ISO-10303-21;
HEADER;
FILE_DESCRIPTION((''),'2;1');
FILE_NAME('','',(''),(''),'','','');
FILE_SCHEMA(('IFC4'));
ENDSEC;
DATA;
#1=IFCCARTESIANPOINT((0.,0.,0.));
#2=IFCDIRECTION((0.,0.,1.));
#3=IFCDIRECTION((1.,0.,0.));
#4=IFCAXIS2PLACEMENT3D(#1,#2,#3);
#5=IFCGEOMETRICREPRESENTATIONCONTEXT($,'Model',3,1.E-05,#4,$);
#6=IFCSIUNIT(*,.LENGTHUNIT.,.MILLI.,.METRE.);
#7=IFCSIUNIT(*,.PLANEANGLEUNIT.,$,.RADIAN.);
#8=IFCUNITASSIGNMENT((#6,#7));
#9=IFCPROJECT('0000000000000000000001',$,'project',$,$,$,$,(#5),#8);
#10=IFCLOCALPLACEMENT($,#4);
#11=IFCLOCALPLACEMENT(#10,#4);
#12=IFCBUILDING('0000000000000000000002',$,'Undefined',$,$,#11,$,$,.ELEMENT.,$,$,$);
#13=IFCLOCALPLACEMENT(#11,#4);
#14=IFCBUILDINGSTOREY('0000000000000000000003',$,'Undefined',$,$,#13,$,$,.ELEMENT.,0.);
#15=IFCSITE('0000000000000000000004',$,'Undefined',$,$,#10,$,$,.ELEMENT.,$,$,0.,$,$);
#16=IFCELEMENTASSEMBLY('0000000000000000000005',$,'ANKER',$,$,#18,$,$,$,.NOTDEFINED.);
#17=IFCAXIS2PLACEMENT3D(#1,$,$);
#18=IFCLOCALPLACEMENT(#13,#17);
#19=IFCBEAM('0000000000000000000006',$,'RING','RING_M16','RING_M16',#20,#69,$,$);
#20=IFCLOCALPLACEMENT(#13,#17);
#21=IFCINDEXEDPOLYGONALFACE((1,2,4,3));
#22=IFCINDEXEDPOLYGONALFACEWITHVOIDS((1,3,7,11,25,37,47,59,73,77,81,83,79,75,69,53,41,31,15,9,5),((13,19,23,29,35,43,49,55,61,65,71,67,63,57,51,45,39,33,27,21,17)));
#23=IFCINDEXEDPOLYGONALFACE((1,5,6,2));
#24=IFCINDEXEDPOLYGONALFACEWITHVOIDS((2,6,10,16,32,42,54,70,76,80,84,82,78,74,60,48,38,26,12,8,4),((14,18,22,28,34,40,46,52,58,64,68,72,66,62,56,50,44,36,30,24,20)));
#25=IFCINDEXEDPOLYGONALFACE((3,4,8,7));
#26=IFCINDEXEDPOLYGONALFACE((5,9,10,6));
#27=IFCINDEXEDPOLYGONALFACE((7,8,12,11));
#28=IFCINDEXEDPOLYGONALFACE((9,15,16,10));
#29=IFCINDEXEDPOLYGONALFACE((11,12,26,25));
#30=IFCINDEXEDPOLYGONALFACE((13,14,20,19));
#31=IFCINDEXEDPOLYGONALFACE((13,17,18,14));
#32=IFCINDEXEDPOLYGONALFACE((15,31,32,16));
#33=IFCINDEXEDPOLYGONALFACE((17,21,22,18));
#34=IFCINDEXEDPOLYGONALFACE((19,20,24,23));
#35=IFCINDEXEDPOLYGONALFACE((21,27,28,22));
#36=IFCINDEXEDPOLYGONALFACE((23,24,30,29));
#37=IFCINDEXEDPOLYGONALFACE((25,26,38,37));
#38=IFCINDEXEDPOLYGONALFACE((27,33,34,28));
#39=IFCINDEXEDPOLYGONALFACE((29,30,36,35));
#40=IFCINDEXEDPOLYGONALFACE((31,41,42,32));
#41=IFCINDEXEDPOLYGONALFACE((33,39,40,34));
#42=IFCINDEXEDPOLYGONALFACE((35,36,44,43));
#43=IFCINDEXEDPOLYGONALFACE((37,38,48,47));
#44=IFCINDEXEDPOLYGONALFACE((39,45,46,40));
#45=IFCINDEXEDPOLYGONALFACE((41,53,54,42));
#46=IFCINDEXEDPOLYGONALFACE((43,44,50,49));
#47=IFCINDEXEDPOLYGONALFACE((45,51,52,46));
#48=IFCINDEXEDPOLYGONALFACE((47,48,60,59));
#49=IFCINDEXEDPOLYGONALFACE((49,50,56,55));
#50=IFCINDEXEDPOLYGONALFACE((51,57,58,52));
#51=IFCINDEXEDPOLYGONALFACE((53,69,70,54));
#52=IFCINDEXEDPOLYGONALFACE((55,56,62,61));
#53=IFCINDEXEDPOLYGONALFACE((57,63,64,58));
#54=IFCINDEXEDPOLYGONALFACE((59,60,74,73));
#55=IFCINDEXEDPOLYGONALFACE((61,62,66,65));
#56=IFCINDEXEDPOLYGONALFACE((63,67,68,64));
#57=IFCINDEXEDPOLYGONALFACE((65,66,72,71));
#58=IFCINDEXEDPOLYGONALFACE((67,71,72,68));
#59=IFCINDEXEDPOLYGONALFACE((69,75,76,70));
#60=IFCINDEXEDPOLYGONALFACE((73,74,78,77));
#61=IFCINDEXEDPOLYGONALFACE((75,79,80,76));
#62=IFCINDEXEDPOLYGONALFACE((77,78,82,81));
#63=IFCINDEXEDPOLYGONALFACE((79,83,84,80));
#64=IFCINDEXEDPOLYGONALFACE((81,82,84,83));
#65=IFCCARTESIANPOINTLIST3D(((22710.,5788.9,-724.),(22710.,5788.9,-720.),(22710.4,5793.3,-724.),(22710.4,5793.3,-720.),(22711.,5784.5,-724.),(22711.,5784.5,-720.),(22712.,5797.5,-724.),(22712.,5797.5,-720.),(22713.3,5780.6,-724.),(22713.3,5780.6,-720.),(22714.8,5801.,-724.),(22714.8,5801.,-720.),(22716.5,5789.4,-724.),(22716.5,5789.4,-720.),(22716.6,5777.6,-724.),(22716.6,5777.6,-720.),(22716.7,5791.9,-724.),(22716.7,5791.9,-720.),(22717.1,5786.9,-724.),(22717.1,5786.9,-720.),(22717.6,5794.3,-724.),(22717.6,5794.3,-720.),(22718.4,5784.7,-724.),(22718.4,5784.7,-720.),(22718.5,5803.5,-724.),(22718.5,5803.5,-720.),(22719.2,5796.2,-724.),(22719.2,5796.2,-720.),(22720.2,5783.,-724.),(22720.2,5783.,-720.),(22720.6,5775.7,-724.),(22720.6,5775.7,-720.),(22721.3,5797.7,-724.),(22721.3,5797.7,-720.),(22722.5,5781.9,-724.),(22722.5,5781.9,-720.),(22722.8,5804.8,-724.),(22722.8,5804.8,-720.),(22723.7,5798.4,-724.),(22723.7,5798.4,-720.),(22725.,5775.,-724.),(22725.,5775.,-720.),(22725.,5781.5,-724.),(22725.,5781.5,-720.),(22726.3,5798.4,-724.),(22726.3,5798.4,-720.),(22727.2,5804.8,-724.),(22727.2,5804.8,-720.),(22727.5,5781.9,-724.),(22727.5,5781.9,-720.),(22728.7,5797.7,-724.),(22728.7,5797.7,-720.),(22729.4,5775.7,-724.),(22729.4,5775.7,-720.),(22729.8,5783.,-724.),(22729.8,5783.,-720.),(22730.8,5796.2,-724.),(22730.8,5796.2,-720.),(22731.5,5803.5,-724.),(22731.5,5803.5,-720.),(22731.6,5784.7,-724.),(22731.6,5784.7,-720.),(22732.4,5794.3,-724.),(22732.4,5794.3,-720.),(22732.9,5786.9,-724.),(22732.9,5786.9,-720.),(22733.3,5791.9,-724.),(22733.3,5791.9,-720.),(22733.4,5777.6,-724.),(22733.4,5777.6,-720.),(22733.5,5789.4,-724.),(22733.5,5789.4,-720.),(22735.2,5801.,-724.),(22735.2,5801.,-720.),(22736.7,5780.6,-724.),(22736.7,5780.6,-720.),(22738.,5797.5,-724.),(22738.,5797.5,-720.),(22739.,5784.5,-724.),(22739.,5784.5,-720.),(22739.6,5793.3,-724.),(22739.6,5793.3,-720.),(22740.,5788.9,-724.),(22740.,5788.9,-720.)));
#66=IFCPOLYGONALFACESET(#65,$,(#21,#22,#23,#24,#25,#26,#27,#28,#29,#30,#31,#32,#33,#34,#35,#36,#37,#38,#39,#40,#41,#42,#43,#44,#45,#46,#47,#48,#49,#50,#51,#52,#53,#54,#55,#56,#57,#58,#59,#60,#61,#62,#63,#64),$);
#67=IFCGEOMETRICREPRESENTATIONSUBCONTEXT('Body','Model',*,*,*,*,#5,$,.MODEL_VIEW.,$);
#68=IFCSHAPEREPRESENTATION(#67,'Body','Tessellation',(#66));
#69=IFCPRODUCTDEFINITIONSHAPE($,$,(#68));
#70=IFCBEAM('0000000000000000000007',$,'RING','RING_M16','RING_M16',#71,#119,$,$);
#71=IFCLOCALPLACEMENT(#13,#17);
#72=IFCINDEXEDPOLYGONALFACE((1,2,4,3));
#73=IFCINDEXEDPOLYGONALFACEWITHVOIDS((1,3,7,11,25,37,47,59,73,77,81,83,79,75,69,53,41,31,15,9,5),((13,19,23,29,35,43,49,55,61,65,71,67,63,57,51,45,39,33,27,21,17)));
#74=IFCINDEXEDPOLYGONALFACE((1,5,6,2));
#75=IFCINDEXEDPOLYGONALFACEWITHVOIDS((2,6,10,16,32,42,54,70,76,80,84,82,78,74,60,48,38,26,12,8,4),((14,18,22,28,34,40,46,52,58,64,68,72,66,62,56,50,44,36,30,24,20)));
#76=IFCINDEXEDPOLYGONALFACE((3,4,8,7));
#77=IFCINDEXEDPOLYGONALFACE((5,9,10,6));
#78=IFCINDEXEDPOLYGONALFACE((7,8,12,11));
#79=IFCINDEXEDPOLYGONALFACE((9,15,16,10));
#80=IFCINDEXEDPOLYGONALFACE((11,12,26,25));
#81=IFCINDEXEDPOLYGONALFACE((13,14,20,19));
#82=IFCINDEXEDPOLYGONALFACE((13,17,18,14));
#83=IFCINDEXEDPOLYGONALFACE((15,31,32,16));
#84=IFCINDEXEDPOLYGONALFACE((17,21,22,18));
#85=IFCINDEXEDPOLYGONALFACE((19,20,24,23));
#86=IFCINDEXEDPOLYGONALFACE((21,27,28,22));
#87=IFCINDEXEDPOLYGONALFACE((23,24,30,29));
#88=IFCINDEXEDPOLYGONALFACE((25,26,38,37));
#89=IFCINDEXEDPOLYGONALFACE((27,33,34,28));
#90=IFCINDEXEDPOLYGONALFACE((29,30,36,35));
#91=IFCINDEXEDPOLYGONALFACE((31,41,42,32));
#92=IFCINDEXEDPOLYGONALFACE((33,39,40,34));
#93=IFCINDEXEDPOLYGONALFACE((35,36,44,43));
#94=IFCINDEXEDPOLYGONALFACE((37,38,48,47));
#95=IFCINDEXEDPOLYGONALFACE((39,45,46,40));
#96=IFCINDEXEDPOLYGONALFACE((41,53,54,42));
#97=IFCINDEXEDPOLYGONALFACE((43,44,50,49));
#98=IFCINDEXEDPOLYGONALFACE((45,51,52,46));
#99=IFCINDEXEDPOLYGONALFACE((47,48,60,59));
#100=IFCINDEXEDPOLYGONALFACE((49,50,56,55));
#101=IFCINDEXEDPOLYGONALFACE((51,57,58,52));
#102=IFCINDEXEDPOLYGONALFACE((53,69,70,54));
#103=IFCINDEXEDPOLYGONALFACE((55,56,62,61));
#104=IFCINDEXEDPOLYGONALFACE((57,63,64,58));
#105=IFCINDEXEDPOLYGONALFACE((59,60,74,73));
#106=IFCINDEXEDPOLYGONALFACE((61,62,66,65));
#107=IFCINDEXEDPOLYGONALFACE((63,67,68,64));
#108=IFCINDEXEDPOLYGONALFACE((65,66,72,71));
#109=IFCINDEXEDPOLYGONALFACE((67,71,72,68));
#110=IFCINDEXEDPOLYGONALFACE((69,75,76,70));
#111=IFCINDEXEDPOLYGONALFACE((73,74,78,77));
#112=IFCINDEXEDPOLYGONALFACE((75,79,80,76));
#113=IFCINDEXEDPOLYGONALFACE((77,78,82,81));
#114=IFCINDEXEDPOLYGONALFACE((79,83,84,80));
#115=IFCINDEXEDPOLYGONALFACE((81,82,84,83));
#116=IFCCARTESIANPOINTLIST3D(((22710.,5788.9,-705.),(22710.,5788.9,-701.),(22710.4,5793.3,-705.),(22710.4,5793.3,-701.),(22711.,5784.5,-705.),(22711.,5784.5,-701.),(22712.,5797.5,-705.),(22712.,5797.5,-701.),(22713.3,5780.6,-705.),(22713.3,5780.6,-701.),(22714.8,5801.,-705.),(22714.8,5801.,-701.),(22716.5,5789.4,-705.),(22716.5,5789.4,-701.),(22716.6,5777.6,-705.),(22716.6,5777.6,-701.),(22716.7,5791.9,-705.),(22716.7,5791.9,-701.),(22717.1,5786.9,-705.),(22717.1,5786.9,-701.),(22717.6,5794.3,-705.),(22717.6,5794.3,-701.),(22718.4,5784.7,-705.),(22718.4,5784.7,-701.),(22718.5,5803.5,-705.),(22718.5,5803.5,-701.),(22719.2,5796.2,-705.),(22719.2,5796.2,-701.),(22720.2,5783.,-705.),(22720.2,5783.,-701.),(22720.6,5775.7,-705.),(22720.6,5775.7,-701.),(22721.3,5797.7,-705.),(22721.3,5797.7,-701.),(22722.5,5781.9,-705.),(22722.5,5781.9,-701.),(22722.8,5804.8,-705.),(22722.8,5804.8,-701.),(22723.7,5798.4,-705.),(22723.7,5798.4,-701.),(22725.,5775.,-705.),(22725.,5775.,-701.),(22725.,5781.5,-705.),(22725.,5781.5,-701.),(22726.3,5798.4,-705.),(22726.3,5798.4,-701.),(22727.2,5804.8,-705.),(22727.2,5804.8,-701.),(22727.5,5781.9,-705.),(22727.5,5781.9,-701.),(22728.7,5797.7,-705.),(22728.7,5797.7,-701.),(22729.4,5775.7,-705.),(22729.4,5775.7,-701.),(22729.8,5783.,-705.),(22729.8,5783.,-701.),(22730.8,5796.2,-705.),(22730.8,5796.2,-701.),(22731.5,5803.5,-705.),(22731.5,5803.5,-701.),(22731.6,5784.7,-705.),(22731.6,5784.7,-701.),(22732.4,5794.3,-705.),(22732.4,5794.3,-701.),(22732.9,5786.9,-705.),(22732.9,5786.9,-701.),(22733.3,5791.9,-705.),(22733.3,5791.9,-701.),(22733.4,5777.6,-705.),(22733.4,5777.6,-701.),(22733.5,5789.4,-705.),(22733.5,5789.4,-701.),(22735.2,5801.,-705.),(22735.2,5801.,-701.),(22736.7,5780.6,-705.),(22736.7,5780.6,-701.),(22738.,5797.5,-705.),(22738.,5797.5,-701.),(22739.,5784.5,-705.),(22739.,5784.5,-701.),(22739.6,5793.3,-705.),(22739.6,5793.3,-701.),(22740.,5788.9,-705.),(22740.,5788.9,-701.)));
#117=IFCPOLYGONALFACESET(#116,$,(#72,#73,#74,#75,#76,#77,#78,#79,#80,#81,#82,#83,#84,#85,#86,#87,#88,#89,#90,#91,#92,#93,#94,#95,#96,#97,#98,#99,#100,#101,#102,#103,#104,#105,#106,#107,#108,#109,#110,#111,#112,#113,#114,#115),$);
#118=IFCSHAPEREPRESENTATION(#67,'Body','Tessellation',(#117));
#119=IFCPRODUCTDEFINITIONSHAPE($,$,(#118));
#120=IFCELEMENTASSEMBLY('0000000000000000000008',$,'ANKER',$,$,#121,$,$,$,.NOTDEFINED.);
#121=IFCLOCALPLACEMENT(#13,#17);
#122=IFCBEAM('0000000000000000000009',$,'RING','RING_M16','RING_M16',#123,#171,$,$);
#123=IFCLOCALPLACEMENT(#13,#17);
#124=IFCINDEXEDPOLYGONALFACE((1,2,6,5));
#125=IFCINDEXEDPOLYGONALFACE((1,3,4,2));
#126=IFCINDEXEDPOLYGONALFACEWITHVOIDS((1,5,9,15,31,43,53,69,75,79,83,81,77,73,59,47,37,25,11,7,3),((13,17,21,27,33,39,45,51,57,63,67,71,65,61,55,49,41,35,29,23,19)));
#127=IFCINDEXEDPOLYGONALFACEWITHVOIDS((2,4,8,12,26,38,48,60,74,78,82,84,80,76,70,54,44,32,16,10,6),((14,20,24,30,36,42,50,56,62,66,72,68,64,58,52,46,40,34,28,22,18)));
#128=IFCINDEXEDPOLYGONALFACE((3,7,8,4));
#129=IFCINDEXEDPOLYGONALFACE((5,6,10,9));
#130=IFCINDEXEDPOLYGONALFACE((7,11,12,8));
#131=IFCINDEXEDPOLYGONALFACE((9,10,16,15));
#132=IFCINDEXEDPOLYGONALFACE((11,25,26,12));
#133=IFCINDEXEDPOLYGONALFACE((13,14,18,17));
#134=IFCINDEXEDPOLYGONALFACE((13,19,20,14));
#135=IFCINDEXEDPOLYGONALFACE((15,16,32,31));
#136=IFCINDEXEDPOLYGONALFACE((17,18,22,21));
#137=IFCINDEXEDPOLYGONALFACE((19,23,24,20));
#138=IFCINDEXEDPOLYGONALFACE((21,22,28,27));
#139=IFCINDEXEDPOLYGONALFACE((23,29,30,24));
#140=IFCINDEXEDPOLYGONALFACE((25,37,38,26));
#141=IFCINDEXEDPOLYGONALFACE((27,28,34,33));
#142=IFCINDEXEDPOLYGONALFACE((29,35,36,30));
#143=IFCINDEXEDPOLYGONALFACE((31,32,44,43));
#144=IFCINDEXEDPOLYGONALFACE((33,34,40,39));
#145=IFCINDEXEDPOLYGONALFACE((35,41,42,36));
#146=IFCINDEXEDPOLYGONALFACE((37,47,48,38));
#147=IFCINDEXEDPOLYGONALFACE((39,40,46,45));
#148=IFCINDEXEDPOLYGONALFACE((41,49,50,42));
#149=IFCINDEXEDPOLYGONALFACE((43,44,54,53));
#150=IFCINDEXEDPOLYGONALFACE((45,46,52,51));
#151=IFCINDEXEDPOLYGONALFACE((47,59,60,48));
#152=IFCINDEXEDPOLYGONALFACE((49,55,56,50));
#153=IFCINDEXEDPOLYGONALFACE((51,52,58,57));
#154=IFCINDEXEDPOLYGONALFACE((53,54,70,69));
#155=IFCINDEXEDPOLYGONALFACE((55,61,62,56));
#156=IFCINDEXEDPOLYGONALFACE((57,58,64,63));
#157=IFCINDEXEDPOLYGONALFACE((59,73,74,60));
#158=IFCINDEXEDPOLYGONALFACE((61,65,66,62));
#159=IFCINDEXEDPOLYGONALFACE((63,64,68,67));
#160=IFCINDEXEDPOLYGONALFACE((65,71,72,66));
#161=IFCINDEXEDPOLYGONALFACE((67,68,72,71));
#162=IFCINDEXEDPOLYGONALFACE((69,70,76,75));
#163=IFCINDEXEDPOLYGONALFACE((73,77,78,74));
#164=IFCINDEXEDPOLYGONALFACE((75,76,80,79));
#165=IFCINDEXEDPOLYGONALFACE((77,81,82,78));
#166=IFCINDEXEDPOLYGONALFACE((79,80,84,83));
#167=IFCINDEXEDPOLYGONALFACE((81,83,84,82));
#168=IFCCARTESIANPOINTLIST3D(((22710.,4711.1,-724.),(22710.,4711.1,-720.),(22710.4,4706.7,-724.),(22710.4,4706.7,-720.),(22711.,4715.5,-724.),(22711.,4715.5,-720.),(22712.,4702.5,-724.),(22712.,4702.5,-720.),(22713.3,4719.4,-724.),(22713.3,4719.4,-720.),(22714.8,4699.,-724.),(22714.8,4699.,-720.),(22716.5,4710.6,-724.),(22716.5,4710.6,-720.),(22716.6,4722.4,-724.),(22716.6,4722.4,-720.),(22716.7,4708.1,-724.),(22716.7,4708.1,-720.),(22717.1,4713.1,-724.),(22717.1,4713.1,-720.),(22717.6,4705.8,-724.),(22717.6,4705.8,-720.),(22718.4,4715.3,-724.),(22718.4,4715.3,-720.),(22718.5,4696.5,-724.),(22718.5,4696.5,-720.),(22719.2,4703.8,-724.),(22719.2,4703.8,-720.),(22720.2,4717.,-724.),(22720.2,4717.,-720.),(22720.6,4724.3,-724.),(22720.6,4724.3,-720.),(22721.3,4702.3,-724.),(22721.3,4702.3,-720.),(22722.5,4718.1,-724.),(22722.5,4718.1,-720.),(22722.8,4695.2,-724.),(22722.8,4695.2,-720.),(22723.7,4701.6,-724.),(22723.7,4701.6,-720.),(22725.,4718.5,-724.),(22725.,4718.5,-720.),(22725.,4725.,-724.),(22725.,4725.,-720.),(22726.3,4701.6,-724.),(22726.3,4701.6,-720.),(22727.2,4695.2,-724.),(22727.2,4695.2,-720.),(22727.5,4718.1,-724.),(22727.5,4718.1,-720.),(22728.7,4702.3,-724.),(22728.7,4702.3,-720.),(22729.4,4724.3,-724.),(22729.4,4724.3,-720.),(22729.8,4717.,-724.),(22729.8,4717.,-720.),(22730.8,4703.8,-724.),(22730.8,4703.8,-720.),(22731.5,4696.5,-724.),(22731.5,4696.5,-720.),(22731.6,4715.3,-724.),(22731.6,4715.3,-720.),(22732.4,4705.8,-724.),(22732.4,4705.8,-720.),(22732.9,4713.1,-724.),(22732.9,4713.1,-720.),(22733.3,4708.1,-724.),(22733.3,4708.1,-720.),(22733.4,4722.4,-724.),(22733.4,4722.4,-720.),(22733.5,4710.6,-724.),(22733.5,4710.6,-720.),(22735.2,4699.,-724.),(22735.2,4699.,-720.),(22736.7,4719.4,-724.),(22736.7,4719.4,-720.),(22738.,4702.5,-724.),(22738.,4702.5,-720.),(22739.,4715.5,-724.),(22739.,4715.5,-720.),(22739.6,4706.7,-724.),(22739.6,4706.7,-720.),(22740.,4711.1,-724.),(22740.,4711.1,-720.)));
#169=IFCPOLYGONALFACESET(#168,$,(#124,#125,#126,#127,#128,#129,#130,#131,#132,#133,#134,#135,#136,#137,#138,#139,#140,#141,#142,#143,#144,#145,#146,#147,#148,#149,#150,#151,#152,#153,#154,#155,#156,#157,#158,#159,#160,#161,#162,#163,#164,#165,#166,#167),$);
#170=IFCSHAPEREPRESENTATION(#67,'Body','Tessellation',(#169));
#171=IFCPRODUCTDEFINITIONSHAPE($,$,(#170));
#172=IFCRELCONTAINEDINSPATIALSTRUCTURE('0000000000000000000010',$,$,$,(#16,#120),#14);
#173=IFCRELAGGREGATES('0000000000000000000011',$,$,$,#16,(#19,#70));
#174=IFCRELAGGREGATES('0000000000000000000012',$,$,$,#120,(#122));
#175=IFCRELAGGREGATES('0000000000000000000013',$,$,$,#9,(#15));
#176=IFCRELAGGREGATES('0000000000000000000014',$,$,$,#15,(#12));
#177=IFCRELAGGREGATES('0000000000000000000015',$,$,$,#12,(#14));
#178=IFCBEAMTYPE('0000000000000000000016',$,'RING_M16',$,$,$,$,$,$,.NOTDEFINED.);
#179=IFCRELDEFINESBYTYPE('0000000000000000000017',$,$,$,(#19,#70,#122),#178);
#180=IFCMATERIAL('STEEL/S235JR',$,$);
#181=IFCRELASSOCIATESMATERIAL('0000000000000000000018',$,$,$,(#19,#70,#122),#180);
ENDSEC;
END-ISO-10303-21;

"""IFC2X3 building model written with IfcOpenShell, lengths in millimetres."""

from ifc_helpers import new_model, si_unit, frame, origin_with_axes, origin_2d_with_axis, place, context, subcontext, project, spatial, hollow_circle, extrude, material, type_object, element, aggregate, save


model = new_model("IFC2X3")

# Units and contexts
model_context = context("Model", 3, precision=1e-05, world=origin_with_axes())
body_context = subcontext(model_context, "Body", "Model", "MODEL_VIEW")
ifc_project = project(units=[si_unit("LENGTHUNIT", "METRE", prefix="MILLI"), si_unit("PLANEANGLEUNIT", "RADIAN")], contexts=[model_context])

# Site, building, storey
site_placement = place(None, origin_with_axes())
site = spatial("IfcSite", under=ifc_project, at=site_placement, Name="Undefined", CompositionType="ELEMENT", RefElevation=0.0)
building_placement = place(site_placement, origin_with_axes())
building = spatial("IfcBuilding", under=site, at=building_placement, Name="Undefined", CompositionType="ELEMENT")
storey_placement = place(building_placement, origin_with_axes())
storey = spatial("IfcBuildingStorey", under=building, at=storey_placement, Name="Undefined", CompositionType="ELEMENT", Elevation=0.0)

# Shared definitions
ifc_material = material(Name="STEEL/S235JR")

# Element assemblies, beams
beam_type_1 = type_object("IfcBeamType", Name="RING_M16", PredefinedType="NOTDEFINED")
assembly_1_placement = place(storey_placement, frame((22725.0, 5790.0, -655.0), z_axis=(1.0, 0.0, 0.0), x_axis=(0.0, 0.0, -1.0)))
assembly_1 = element("IfcElementAssembly", 1, at=assembly_1_placement, inside=storey, Name="ANKER", PredefinedType="NOTDEFINED")
beam_1_placement = place(storey_placement, frame((22725.0, 5790.0, -720.0), z_axis=(1.0, 0.0, 0.0), x_axis=(0.0, 0.0, -1.0)))
beam_1 = element("IfcBeam", 2, at=beam_1_placement, type_object=beam_type_1, material=ifc_material, Name="RING", Description="RING_M16", ObjectType="RING_M16", context=body_context, shape_type="SweptSolid", body=[
    extrude(hollow_circle(Radius=15.0, WallThickness=6.5, at=origin_2d_with_axis()), frame((4.0, 0.0, 0.0), z_axis=(-1.0, 0.0, 0.0), x_axis=(0.0, -1.0, 0.0)), (0.0, 0.0, 1.0), 4.0),
])
beam_2_placement = place(storey_placement, frame((22725.0, 5790.0, -701.0), z_axis=(1.0, 0.0, 0.0), x_axis=(0.0, 0.0, -1.0)))
beam_2 = element("IfcBeam", 3, at=beam_2_placement, type_object=beam_type_1, material=ifc_material, Name="RING", Description="RING_M16", ObjectType="RING_M16", context=body_context, shape_type="SweptSolid", body=[
    extrude(hollow_circle(Radius=15.0, WallThickness=6.5, at=origin_2d_with_axis()), frame((4.0, 0.0, 0.0), z_axis=(-1.0, 0.0, 0.0), x_axis=(0.0, -1.0, 0.0)), (0.0, 0.0, 1.0), 4.0),
])
aggregate(assembly_1, [beam_1, beam_2])
assembly_2_placement = place(storey_placement, frame((22725.0, 4710.0, -655.0), z_axis=(-1.0, 0.0, 0.0), x_axis=(0.0, 0.0, -1.0)))
assembly_2 = element("IfcElementAssembly", 4, at=assembly_2_placement, inside=storey, Name="ANKER", PredefinedType="NOTDEFINED")
beam_3_placement = place(storey_placement, frame((22725.0, 4710.0, -720.0), z_axis=(-1.0, 0.0, 0.0), x_axis=(0.0, 0.0, -1.0)))
beam_3 = element("IfcBeam", 5, at=beam_3_placement, type_object=beam_type_1, material=ifc_material, Name="RING", Description="RING_M16", ObjectType="RING_M16", context=body_context, shape_type="SweptSolid", body=[
    extrude(hollow_circle(Radius=15.0, WallThickness=6.5, at=origin_2d_with_axis()), frame((4.0, 0.0, 0.0), z_axis=(-1.0, 0.0, 0.0), x_axis=(0.0, -1.0, 0.0)), (0.0, 0.0, 1.0), 4.0),
])
aggregate(assembly_2, [beam_3])

save(model, "model.ifc")
